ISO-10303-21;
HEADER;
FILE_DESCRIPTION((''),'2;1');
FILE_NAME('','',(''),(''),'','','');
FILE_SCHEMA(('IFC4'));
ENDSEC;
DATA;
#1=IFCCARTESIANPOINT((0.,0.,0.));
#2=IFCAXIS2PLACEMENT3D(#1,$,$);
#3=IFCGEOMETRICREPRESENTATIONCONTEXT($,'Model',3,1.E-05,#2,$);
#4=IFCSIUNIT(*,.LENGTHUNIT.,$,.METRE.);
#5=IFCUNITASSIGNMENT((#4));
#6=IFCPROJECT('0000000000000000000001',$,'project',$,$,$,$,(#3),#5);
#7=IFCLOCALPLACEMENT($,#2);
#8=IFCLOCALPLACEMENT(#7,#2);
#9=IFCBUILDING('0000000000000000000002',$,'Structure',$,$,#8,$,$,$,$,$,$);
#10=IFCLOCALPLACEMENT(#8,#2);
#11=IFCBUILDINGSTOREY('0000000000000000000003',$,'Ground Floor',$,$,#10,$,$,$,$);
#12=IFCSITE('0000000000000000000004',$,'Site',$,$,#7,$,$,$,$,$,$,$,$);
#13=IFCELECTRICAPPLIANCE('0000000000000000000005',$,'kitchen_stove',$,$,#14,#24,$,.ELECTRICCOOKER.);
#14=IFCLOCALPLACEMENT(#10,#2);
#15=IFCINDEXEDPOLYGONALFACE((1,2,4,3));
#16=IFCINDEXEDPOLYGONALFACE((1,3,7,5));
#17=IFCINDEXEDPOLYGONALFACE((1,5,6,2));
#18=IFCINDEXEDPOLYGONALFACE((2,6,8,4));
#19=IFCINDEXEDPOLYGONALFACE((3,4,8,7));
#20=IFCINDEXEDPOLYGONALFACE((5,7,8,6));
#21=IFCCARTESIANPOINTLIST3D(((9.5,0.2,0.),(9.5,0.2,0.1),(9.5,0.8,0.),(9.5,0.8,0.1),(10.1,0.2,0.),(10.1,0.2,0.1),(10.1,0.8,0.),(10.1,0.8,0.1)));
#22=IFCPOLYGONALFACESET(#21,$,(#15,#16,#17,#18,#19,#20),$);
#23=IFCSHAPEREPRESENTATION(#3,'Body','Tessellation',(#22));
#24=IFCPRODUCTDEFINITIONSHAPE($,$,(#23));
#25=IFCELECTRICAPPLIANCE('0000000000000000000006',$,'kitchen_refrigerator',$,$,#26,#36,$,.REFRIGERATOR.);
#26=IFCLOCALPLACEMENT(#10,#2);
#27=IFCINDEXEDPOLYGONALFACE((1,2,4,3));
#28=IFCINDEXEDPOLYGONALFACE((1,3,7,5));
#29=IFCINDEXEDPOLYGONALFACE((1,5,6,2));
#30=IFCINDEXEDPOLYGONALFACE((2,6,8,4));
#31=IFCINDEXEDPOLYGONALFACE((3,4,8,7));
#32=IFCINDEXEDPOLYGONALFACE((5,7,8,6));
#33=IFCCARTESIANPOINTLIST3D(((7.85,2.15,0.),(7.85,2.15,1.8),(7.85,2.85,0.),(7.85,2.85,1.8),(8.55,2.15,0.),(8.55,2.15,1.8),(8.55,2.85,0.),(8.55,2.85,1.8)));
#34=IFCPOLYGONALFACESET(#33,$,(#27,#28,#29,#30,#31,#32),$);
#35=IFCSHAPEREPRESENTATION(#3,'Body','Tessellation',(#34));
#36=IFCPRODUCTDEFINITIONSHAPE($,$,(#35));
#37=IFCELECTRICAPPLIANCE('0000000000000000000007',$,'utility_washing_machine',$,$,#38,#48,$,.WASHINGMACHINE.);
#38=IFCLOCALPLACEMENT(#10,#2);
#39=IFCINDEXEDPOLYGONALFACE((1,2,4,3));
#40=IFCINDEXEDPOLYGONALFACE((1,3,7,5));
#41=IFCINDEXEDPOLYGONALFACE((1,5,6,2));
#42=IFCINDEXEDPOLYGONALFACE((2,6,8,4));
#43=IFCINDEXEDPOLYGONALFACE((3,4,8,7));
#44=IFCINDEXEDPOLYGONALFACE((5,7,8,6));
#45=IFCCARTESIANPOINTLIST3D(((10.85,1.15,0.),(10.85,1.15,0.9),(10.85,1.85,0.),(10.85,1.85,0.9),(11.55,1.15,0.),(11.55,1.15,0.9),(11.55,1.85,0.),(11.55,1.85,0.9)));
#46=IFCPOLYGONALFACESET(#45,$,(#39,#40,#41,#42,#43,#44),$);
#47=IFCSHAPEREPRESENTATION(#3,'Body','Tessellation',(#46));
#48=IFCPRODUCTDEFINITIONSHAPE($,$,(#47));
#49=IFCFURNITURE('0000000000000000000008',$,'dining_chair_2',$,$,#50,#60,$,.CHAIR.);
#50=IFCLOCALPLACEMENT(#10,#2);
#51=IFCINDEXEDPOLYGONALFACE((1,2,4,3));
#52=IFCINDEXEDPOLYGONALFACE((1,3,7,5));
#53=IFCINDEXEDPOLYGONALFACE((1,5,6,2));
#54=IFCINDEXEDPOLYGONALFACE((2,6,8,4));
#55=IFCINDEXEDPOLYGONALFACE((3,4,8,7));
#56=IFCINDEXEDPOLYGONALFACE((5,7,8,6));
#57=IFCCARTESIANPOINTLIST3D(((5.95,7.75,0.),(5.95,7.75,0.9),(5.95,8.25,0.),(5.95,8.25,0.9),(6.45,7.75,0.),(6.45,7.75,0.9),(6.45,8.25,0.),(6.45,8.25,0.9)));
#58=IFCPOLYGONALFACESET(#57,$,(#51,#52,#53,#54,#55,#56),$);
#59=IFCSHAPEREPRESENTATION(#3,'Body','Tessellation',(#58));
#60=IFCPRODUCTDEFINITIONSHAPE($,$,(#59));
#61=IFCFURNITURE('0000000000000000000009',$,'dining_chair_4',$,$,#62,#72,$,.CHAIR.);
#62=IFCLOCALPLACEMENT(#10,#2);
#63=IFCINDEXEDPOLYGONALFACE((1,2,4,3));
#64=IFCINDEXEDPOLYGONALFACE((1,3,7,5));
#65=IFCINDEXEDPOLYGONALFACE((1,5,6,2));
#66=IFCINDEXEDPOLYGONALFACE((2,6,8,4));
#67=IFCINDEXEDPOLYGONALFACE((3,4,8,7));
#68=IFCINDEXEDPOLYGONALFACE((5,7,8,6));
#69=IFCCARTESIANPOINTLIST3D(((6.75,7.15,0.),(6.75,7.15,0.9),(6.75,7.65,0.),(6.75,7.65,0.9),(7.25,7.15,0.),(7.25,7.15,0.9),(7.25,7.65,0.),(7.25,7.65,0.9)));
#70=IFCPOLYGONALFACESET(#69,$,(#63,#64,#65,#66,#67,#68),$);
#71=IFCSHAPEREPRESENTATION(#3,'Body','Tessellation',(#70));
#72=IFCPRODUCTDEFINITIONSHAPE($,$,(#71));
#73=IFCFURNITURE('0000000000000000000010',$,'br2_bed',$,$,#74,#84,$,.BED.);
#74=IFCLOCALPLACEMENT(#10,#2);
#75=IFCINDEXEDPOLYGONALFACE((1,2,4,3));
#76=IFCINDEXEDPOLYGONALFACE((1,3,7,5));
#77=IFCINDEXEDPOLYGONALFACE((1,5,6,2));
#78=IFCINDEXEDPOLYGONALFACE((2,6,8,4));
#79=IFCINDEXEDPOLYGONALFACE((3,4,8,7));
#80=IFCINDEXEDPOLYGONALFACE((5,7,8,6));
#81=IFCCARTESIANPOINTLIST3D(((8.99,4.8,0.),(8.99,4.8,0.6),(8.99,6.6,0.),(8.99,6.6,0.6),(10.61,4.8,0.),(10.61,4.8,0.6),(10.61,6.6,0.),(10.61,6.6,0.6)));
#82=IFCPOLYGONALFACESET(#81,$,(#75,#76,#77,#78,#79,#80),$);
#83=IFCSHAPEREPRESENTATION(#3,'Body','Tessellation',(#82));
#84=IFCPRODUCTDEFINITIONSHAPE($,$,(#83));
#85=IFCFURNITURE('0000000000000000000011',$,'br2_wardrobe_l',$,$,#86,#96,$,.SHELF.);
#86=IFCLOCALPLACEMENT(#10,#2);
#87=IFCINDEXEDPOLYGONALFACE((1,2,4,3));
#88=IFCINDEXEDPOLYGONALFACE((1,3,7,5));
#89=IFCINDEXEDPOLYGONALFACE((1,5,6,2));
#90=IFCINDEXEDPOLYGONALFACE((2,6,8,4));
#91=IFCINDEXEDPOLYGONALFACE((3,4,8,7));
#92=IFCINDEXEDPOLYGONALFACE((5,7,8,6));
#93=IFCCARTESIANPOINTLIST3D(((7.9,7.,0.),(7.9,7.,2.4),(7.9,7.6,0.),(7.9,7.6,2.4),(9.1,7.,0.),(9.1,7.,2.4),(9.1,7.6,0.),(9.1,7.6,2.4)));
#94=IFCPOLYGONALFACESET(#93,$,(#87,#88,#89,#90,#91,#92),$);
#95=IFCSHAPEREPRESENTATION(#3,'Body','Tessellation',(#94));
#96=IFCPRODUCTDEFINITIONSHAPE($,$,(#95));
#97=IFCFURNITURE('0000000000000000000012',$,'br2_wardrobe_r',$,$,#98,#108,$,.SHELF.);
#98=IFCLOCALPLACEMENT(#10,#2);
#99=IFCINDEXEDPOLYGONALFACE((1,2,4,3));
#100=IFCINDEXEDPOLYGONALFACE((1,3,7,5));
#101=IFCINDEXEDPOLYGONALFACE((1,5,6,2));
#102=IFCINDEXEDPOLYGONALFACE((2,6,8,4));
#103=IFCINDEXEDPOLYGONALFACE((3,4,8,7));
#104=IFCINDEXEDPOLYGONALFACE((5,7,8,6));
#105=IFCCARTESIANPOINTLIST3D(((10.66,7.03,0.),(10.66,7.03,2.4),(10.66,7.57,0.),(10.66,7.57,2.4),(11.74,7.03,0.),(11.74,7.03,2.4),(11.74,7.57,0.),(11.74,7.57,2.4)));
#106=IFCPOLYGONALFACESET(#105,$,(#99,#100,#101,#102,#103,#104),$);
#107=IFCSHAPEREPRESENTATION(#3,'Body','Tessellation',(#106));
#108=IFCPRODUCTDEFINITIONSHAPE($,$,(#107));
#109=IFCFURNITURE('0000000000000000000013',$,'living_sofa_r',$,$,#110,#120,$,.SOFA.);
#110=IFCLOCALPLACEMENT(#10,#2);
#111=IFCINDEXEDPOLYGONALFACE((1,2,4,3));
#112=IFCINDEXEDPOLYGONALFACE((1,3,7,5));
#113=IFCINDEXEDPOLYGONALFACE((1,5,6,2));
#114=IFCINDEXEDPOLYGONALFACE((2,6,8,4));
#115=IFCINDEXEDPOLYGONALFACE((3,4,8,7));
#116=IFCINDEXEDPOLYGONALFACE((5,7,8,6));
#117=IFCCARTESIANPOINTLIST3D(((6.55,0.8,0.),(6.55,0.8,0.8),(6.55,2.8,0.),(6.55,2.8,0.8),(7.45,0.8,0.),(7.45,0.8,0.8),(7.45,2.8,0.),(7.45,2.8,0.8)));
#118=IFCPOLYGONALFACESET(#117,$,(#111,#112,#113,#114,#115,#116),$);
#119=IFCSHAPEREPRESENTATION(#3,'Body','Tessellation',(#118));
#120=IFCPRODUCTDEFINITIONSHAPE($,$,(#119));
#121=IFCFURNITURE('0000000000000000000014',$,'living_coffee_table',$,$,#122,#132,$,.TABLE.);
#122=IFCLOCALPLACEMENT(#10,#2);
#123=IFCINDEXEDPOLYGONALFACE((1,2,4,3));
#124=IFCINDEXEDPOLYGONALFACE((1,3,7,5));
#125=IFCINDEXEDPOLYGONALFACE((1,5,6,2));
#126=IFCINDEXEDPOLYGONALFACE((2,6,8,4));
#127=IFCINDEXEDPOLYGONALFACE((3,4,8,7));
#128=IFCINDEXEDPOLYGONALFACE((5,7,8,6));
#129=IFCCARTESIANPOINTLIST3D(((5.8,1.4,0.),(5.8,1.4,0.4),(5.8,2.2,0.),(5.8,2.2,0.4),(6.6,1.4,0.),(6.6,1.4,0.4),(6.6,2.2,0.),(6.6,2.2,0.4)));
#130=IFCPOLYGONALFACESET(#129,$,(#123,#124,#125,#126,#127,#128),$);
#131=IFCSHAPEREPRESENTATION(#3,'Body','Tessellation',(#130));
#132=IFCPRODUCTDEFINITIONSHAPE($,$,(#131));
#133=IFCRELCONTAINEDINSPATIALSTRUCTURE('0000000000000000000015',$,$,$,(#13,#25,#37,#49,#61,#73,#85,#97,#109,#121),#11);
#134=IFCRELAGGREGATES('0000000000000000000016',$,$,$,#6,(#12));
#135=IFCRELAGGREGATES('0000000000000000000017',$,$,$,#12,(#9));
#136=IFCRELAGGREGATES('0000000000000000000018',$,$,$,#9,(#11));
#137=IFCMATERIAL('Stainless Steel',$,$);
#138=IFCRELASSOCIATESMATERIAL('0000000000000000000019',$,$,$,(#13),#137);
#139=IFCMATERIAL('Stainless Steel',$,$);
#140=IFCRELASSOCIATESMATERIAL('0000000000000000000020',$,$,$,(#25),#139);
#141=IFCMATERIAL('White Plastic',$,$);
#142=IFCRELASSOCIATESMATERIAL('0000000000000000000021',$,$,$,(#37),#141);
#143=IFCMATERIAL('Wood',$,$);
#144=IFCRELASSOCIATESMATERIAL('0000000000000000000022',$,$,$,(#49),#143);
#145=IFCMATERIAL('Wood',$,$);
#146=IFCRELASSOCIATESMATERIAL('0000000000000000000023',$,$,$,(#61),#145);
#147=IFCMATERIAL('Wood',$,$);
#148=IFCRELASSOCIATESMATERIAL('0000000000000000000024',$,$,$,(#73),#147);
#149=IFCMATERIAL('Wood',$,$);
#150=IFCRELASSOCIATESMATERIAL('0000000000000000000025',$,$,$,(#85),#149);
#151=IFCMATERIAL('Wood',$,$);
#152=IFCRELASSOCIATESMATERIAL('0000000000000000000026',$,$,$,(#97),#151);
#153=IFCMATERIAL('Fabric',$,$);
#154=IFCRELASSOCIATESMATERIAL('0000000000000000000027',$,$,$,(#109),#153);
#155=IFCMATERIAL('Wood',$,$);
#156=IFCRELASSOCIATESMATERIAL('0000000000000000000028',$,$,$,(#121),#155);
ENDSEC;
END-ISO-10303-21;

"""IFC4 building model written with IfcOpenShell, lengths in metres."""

from ifc_helpers import new_model, si_unit, frame, origin, place, context, project, spatial, polyline, outline, extrude, material, element, save


model = new_model("IFC4")

# Units and contexts
model_context = context("Model", 3, precision=1e-05, world=origin())
ifc_project = project(units=[si_unit("LENGTHUNIT", "METRE")], contexts=[model_context])

# Site, building, storey
site_placement = place(None, origin())
site = spatial("IfcSite", under=ifc_project, at=site_placement, Name="Site")
building_placement = place(site_placement, origin())
building = spatial("IfcBuilding", under=site, at=building_placement, Name="Structure")
storey_placement = place(building_placement, origin())
storey = spatial("IfcBuildingStorey", under=building, at=storey_placement, Name="Ground Floor")

# Electric appliances
ifc_material_1 = material(Name="Stainless Steel")
electric_appliance_1_placement = place(storey_placement, frame((9.8, 0.5, 0.0)))
element("IfcElectricAppliance", 1, at=electric_appliance_1_placement, inside=storey, material=ifc_material_1, Name="kitchen_stove", PredefinedType="ELECTRICCOOKER", context=model_context, shape_type="SweptSolid", body=[
    extrude(outline(polyline([(-0.3, -0.3), (0.3, -0.3), (0.3, 0.3), (-0.3, 0.3), (-0.3, -0.3)])), origin(), (0.0, 0.0, 1.0), 0.1),
])
ifc_material_2 = material(Name="Stainless Steel")
electric_appliance_2_placement = place(storey_placement, frame((8.2, 2.5, 0.0)))
element("IfcElectricAppliance", 2, at=electric_appliance_2_placement, inside=storey, material=ifc_material_2, Name="kitchen_refrigerator", PredefinedType="REFRIGERATOR", context=model_context, shape_type="SweptSolid", body=[
    extrude(outline(polyline([(-0.35, -0.35), (0.35, -0.35), (0.35, 0.35), (-0.35, 0.35), (-0.35, -0.35)])), origin(), (0.0, 0.0, 1.0), 1.8),
])
ifc_material_3 = material(Name="White Plastic")
electric_appliance_3_placement = place(storey_placement, frame((11.2, 1.5, 0.0)))
element("IfcElectricAppliance", 3, at=electric_appliance_3_placement, inside=storey, material=ifc_material_3, Name="utility_washing_machine", PredefinedType="WASHINGMACHINE", context=model_context, shape_type="SweptSolid", body=[
    extrude(outline(polyline([(-0.35, -0.35), (0.35, -0.35), (0.35, 0.35), (-0.35, 0.35), (-0.35, -0.35)])), origin(), (0.0, 0.0, 1.0), 0.9),
])

# Furniture
ifc_material_4 = material(Name="Wood")
furniture_1_placement = place(storey_placement, frame((6.2, 8.0, 0.0)))
element("IfcFurniture", 4, at=furniture_1_placement, inside=storey, material=ifc_material_4, Name="dining_chair_2", PredefinedType="CHAIR", context=model_context, shape_type="SweptSolid", body=[
    extrude(outline(polyline([(-0.25, -0.25), (0.25, -0.25), (0.25, 0.25), (-0.25, 0.25), (-0.25, -0.25)])), origin(), (0.0, 0.0, 1.0), 0.9),
])
ifc_material_5 = material(Name="Wood")
furniture_2_placement = place(storey_placement, frame((7.0, 7.4, 0.0)))
element("IfcFurniture", 5, at=furniture_2_placement, inside=storey, material=ifc_material_5, Name="dining_chair_4", PredefinedType="CHAIR", context=model_context, shape_type="SweptSolid", body=[
    extrude(outline(polyline([(-0.25, -0.25), (0.25, -0.25), (0.25, 0.25), (-0.25, 0.25), (-0.25, -0.25)])), origin(), (0.0, 0.0, 1.0), 0.9),
])
ifc_material_6 = material(Name="Wood")
furniture_3_placement = place(storey_placement, frame((9.8, 5.7, 0.0)))
element("IfcFurniture", 6, at=furniture_3_placement, inside=storey, material=ifc_material_6, Name="br2_bed", PredefinedType="BED", context=model_context, shape_type="SweptSolid", body=[
    extrude(outline(polyline([(-0.81, -0.9), (0.81, -0.9), (0.81, 0.9), (-0.81, 0.9), (-0.81, -0.9)])), origin(), (0.0, 0.0, 1.0), 0.6),
])
ifc_material_7 = material(Name="Wood")
furniture_4_placement = place(storey_placement, frame((8.5, 7.3, 0.0)))
element("IfcFurniture", 7, at=furniture_4_placement, inside=storey, material=ifc_material_7, Name="br2_wardrobe_l", PredefinedType="SHELF", context=model_context, shape_type="SweptSolid", body=[
    extrude(outline(polyline([(-0.6, -0.3), (0.6, -0.3), (0.6, 0.3), (-0.6, 0.3), (-0.6, -0.3)])), origin(), (0.0, 0.0, 1.0), 2.4),
])
ifc_material_8 = material(Name="Wood")
furniture_5_placement = place(storey_placement, frame((11.2, 7.3, 0.0)))
element("IfcFurniture", 8, at=furniture_5_placement, inside=storey, material=ifc_material_8, Name="br2_wardrobe_r", PredefinedType="SHELF", context=model_context, shape_type="SweptSolid", body=[
    extrude(outline(polyline([(-0.54, -0.27), (0.54, -0.27), (0.54, 0.27), (-0.54, 0.27), (-0.54, -0.27)])), origin(), (0.0, 0.0, 1.0), 2.4),
])
ifc_material_9 = material(Name="Fabric")
furniture_6_placement = place(storey_placement, frame((7.0, 1.8, 0.0)))
element("IfcFurniture", 9, at=furniture_6_placement, inside=storey, material=ifc_material_9, Name="living_sofa_r", PredefinedType="SOFA", context=model_context, shape_type="SweptSolid", body=[
    extrude(outline(polyline([(-0.45, -1.0), (0.45, -1.0), (0.45, 1.0), (-0.45, 1.0), (-0.45, -1.0)])), origin(), (0.0, 0.0, 1.0), 0.8),
])
ifc_material_10 = material(Name="Wood")
furniture_7_placement = place(storey_placement, frame((6.2, 1.8, 0.0)))
element("IfcFurniture", 10, at=furniture_7_placement, inside=storey, material=ifc_material_10, Name="living_coffee_table", PredefinedType="TABLE", context=model_context, shape_type="SweptSolid", body=[
    extrude(outline(polyline([(-0.4, -0.4), (0.4, -0.4), (0.4, 0.4), (-0.4, 0.4), (-0.4, -0.4)])), origin(), (0.0, 0.0, 1.0), 0.4),
])

save(model, "model.ifc")
